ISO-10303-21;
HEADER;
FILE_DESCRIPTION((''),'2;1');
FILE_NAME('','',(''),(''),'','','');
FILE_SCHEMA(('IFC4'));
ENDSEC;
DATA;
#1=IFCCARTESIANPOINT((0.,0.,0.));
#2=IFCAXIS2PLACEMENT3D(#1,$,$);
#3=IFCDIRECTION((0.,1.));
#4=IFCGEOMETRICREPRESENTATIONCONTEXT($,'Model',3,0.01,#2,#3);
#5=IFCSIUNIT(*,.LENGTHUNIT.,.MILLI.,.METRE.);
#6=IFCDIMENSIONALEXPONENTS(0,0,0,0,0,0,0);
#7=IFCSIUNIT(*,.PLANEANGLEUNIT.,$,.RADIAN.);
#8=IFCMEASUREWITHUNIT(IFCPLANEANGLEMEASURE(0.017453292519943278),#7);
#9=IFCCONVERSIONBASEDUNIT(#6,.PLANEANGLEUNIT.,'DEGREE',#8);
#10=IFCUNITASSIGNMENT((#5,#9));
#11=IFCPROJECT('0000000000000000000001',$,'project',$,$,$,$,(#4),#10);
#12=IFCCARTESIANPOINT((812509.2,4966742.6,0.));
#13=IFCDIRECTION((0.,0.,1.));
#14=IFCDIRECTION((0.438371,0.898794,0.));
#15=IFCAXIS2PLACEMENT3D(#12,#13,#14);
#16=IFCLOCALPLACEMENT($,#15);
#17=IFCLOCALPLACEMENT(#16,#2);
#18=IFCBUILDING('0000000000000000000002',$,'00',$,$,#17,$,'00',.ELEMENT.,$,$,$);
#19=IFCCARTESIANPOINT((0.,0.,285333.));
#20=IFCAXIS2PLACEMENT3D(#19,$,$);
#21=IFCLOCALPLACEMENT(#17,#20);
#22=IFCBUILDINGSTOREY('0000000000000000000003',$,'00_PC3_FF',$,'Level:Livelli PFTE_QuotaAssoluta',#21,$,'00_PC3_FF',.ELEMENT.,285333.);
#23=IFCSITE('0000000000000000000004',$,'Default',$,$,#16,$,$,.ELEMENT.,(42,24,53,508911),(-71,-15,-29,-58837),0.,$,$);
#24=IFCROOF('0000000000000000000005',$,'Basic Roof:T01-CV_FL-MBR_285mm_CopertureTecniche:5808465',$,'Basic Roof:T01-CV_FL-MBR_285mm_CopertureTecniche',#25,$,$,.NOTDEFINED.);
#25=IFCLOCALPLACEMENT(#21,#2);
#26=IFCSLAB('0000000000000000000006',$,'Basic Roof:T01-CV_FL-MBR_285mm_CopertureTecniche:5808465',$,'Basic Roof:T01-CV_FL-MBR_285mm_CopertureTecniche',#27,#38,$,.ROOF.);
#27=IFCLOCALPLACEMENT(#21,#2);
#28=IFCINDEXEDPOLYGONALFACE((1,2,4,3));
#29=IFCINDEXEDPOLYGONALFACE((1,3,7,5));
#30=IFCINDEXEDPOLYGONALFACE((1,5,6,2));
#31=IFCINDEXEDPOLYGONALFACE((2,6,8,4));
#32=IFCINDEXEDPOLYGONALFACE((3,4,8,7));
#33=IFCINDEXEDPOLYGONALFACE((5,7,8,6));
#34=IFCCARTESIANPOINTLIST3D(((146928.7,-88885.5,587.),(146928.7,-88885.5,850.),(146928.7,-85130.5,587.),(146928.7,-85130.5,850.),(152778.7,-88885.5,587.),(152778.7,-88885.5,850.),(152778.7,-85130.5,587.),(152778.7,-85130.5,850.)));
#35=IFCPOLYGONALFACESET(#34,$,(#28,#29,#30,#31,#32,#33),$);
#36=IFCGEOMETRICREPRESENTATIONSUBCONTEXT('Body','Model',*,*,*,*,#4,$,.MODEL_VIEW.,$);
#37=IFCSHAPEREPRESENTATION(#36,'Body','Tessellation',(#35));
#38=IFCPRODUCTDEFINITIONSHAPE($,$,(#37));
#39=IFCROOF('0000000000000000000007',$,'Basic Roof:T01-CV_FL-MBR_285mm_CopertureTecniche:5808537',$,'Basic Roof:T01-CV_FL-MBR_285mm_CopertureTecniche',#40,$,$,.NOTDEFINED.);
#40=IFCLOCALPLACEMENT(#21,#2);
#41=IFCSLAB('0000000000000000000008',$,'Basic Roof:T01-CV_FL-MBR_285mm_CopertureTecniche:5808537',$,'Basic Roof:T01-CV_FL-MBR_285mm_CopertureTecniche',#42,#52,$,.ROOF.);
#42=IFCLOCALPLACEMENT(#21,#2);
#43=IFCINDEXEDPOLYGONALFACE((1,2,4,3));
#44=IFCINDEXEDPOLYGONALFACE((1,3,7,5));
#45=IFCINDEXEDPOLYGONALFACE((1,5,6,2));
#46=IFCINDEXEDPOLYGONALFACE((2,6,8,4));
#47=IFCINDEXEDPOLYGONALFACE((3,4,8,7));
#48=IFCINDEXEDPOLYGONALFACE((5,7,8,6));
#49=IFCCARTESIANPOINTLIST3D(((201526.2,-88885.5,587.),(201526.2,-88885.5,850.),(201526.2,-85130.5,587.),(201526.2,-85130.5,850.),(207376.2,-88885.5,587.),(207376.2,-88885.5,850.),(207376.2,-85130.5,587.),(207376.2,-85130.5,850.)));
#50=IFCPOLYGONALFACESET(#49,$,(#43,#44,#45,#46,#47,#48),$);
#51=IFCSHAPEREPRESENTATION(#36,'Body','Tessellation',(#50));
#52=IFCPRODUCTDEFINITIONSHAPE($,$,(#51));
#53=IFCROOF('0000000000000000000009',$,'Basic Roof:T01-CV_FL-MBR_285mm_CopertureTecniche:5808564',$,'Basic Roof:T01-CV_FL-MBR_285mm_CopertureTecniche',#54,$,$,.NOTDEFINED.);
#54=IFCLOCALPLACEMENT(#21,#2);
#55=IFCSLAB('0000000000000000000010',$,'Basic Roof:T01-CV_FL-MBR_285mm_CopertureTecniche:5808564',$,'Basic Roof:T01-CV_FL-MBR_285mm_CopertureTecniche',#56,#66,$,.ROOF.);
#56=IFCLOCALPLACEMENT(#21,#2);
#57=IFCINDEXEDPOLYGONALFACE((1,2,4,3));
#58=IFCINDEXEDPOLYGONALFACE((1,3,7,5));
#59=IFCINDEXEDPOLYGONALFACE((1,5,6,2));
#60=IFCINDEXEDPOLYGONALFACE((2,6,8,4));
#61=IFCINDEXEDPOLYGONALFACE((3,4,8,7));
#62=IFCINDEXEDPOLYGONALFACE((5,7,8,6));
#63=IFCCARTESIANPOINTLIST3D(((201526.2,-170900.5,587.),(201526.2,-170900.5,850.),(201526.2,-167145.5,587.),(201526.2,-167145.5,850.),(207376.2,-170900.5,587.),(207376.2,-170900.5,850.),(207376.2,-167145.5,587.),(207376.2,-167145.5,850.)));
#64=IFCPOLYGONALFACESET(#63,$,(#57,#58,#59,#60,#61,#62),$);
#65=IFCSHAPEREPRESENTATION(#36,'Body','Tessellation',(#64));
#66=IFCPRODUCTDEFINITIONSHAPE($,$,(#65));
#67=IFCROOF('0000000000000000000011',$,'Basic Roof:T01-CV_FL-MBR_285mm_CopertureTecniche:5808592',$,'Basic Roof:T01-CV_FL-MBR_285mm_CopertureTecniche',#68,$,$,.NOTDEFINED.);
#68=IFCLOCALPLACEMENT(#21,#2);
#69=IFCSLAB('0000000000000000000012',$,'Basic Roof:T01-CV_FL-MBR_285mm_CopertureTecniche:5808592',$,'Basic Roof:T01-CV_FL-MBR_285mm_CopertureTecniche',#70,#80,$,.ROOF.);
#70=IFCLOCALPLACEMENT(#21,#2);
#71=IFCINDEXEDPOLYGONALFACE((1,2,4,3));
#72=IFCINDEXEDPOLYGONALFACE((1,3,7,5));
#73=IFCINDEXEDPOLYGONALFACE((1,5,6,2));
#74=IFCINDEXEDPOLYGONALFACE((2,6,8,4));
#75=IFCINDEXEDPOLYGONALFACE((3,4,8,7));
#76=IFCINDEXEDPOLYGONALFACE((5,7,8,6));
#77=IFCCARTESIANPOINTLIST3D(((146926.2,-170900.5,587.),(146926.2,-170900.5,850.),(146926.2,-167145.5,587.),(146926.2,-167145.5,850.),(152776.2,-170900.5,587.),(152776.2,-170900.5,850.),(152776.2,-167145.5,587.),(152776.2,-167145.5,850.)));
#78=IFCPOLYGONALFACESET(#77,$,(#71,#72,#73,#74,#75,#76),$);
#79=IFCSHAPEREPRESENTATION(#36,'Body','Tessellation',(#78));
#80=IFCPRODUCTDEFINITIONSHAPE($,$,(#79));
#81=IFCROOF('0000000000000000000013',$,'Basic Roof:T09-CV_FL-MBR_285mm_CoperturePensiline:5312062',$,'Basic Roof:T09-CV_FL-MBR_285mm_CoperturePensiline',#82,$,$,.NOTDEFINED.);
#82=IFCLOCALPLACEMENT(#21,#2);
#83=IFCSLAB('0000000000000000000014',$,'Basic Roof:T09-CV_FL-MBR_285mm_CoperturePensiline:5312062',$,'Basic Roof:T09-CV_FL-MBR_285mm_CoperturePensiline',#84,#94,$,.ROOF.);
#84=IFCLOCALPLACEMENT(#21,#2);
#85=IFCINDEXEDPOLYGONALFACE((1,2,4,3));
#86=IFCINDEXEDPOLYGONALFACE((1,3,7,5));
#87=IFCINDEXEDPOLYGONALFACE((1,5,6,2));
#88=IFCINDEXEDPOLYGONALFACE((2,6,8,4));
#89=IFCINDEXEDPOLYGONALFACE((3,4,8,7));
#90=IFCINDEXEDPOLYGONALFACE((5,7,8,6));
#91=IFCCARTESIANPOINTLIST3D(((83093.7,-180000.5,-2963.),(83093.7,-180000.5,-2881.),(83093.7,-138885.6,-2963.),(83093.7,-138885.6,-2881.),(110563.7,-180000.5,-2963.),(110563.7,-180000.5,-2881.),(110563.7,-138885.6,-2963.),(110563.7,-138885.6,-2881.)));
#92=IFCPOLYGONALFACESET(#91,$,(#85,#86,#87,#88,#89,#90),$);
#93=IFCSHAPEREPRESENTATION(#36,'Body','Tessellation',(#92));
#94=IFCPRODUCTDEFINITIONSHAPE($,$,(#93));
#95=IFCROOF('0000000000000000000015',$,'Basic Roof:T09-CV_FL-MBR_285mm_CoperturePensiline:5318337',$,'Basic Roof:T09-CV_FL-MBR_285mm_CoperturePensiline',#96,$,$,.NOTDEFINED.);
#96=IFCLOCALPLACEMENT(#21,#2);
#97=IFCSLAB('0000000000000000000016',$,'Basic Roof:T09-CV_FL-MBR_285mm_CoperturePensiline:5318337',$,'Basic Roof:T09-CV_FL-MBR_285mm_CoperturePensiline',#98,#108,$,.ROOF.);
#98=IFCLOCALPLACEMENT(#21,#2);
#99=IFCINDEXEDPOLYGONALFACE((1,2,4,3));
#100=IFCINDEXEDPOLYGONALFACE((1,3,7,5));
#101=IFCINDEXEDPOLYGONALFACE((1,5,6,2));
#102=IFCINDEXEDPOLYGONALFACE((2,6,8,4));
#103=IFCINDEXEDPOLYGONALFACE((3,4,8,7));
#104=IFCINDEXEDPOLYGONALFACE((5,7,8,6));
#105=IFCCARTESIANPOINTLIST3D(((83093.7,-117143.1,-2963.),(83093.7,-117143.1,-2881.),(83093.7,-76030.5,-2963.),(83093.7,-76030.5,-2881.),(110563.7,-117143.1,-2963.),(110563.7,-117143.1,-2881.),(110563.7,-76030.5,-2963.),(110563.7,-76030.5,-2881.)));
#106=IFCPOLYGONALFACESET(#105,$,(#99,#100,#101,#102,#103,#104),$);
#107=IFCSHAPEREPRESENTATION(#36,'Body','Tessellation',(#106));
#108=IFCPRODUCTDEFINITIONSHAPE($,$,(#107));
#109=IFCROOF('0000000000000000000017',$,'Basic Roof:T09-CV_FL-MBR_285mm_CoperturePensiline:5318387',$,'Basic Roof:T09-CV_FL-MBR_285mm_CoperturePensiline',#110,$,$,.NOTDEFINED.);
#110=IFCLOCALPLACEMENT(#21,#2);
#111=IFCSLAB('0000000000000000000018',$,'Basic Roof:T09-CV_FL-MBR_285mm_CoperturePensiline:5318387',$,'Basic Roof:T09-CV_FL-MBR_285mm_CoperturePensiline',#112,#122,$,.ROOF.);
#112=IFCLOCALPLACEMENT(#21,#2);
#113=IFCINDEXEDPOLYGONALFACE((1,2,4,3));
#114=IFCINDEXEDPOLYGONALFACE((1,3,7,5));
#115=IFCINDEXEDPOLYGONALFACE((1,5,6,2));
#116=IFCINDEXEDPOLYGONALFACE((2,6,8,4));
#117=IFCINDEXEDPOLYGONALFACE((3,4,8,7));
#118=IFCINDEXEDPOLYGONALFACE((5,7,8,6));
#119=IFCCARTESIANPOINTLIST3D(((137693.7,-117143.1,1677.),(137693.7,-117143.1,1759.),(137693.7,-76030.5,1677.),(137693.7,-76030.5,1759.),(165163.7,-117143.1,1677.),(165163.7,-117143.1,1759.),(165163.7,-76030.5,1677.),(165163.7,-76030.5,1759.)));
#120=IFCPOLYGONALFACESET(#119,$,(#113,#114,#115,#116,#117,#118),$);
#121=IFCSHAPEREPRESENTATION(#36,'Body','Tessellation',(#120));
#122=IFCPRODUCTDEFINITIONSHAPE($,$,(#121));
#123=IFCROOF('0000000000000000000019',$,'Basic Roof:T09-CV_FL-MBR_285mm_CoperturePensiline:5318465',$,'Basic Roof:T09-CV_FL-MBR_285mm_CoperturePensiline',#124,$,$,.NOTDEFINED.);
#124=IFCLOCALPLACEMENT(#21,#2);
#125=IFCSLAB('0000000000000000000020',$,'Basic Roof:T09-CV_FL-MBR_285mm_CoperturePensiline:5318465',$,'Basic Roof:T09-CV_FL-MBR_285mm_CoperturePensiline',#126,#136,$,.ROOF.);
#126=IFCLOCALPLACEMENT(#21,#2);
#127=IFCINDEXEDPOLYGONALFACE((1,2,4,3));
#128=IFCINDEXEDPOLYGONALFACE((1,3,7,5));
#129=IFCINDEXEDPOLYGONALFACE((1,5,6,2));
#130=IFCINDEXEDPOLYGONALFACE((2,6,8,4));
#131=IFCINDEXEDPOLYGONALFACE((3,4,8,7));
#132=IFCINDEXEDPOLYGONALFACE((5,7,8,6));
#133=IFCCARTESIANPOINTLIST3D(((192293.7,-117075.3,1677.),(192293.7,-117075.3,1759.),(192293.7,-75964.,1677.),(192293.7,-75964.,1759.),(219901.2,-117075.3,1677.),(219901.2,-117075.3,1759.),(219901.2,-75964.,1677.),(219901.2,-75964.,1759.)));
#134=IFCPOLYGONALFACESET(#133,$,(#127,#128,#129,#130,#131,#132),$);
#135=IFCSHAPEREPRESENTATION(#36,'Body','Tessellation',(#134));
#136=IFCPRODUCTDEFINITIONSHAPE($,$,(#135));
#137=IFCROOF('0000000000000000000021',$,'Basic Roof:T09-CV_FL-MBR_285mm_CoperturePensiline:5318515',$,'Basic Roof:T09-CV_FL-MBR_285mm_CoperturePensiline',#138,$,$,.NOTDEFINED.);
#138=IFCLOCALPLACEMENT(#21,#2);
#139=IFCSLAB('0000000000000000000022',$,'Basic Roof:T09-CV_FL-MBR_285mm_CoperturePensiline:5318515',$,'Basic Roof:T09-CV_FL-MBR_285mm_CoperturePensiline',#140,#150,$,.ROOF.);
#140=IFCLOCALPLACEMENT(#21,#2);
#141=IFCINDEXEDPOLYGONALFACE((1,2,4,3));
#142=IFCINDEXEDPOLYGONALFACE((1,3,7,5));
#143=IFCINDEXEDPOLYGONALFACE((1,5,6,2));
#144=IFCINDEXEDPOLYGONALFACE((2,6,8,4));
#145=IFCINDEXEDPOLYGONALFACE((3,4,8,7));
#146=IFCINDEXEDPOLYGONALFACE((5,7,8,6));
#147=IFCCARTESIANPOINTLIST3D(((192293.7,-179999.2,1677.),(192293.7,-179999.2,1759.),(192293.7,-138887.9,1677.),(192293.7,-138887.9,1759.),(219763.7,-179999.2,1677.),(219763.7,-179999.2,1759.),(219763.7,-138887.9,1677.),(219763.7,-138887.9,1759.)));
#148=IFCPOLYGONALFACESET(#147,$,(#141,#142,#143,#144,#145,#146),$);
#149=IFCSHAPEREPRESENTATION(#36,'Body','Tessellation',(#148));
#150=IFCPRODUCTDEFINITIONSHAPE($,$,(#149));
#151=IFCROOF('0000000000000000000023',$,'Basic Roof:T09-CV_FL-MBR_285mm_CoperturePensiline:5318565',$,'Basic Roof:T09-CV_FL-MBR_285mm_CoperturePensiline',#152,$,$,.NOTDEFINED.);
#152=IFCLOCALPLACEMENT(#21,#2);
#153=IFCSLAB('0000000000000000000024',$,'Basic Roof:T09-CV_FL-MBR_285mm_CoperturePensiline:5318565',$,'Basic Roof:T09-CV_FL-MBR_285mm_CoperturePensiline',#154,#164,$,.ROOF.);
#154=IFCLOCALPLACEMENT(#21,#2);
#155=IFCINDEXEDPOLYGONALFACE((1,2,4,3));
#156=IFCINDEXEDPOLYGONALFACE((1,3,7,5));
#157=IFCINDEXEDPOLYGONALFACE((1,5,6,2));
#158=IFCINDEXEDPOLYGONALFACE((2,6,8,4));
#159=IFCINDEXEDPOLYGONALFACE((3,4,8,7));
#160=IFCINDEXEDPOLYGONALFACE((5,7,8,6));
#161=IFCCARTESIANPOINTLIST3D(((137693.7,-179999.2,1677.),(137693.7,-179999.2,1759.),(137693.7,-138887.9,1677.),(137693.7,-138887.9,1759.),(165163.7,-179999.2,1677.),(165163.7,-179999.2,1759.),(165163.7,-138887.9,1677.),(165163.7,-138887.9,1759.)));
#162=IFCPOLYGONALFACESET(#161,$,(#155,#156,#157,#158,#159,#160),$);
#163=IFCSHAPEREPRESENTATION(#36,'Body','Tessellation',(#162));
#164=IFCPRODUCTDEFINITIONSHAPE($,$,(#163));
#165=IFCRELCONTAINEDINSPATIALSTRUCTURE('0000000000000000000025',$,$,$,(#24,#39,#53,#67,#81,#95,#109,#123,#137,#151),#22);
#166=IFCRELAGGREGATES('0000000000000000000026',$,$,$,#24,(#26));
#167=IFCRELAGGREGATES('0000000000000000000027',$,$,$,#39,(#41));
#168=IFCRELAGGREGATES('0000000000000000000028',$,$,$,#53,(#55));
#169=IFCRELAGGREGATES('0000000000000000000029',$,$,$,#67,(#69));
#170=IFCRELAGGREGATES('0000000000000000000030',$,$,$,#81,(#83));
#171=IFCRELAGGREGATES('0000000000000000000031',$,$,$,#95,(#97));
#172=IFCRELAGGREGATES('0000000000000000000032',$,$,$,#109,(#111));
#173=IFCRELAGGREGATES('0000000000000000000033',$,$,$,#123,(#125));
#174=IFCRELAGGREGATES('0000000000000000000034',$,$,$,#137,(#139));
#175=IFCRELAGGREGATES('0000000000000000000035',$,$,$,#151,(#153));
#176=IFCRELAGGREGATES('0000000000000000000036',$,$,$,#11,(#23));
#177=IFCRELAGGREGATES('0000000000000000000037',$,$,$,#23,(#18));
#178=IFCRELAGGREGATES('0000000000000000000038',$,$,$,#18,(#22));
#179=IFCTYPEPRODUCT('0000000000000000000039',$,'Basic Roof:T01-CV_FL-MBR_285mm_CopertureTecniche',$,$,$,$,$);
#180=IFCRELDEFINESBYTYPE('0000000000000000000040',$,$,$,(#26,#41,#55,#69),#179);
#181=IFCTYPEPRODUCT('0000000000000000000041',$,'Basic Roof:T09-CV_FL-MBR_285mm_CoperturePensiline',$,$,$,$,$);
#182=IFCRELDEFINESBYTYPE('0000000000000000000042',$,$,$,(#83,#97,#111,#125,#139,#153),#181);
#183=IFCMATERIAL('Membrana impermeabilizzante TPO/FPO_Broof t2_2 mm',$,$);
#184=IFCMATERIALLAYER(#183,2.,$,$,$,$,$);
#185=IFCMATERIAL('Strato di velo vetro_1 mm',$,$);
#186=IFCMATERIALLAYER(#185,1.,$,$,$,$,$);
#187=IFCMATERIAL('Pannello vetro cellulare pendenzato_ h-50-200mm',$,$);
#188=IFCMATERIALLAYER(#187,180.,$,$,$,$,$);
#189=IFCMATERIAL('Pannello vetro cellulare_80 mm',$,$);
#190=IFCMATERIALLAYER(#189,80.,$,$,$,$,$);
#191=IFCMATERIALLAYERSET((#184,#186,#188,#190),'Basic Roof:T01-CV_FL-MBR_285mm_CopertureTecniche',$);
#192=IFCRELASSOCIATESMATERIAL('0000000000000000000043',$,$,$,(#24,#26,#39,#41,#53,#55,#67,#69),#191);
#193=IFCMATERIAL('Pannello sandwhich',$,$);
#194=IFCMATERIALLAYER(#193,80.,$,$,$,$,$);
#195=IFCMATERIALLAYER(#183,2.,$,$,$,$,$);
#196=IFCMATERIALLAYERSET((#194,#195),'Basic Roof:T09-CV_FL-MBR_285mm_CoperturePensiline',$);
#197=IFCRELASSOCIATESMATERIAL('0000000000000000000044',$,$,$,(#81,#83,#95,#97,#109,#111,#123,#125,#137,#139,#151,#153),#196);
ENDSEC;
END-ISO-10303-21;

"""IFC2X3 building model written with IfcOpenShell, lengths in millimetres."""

from ifc_helpers import new_model, entity, si_unit, converted_unit, direction, frame, frame_2d, origin, origin_2d_with_axis, place, context, subcontext, project, spatial, rectangle, extrude, material, layer, layer_set, type_object, element, aggregate, save


model = new_model("IFC2X3")

# Units and contexts
model_context = context("Model", 3, precision=0.01, world=origin(), true_north=direction((0.0, 1.0)))
body_context = subcontext(model_context, "Body", "Model", "MODEL_VIEW")
ifc_project = project(units=[si_unit("LENGTHUNIT", "METRE", prefix="MILLI"), converted_unit("PLANEANGLEUNIT", "DEGREE", entity("IfcPlaneAngleMeasure", 0.017453292519943278), si_unit("PLANEANGLEUNIT", "RADIAN"), dimensions=[0, 0, 0, 0, 0, 0, 0])], contexts=[model_context])

# Site, building, storey
site_placement = place(None, frame((812509.2, 4966742.6, 0.0), z_axis=(0.0, 0.0, 1.0), x_axis=(0.438371, 0.898794, 0.0)))
site = spatial("IfcSite", under=ifc_project, at=site_placement, Name="Default", CompositionType="ELEMENT", RefLatitude=(42, 24, 53, 508911), RefLongitude=(-71, -15, -29, -58837), RefElevation=0.0)
building_placement = place(site_placement, origin())
building = spatial("IfcBuilding", under=site, at=building_placement, Name="00", LongName="00", CompositionType="ELEMENT")
storey_placement = place(building_placement, frame((0.0, 0.0, 285333.0)))
storey = spatial("IfcBuildingStorey", under=building, at=storey_placement, Name="00_PC3_FF", ObjectType="Level:Livelli PFTE_QuotaAssoluta", LongName="00_PC3_FF", CompositionType="ELEMENT", Elevation=285333.0)

# Roofs, slabs
ifc_material_1 = material(Name="Membrana impermeabilizzante TPO/FPO_Broof t2_2 mm")
ifc_layer_1 = layer(ifc_material_1, 2.0)
ifc_material_2 = material(Name="Strato di velo vetro_1 mm")
ifc_layer_2 = layer(ifc_material_2, 1.0)
ifc_material_3 = material(Name="Pannello vetro cellulare pendenzato_ h-50-200mm")
ifc_layer_3 = layer(ifc_material_3, 180.0)
ifc_material_4 = material(Name="Pannello vetro cellulare_80 mm")
ifc_layer_4 = layer(ifc_material_4, 80.0)
ifc_layer_set_1 = layer_set([ifc_layer_1, ifc_layer_2, ifc_layer_3, ifc_layer_4], Name="Basic Roof:T01-CV_FL-MBR_285mm_CopertureTecniche")
roof_1_placement = place(storey_placement, frame((146928.7, -88885.5, 587.0)))
roof_1 = element("IfcRoof", 1, at=roof_1_placement, inside=storey, material=ifc_layer_set_1, Name="Basic Roof:T01-CV_FL-MBR_285mm_CopertureTecniche:5808465", ObjectType="Basic Roof:T01-CV_FL-MBR_285mm_CopertureTecniche", ShapeType="NOTDEFINED")
type_product_1 = type_object("IfcTypeProduct", Name="Basic Roof:T01-CV_FL-MBR_285mm_CopertureTecniche")
slab_1_placement = place(roof_1_placement, origin())
slab_1 = element("IfcSlab", 2, at=slab_1_placement, type_object=type_product_1, material=ifc_layer_set_1, Name="Basic Roof:T01-CV_FL-MBR_285mm_CopertureTecniche:5808465", ObjectType="Basic Roof:T01-CV_FL-MBR_285mm_CopertureTecniche", PredefinedType="ROOF", context=body_context, shape_type="SweptSolid", body=[
    extrude(rectangle(XDim=5850.0, YDim=3755.0, at=origin_2d_with_axis()), frame((2925.0, 1877.5, 0.0)), (0.0, 0.0, 1.0), 263.0),
])
aggregate(roof_1, [slab_1])
roof_2_placement = place(storey_placement, frame((201526.2, -88885.5, 587.0)))
roof_2 = element("IfcRoof", 3, at=roof_2_placement, inside=storey, material=ifc_layer_set_1, Name="Basic Roof:T01-CV_FL-MBR_285mm_CopertureTecniche:5808537", ObjectType="Basic Roof:T01-CV_FL-MBR_285mm_CopertureTecniche", ShapeType="NOTDEFINED")
slab_2_placement = place(roof_2_placement, origin())
slab_2 = element("IfcSlab", 4, at=slab_2_placement, type_object=type_product_1, material=ifc_layer_set_1, Name="Basic Roof:T01-CV_FL-MBR_285mm_CopertureTecniche:5808537", ObjectType="Basic Roof:T01-CV_FL-MBR_285mm_CopertureTecniche", PredefinedType="ROOF", context=body_context, shape_type="SweptSolid", body=[
    extrude(rectangle(XDim=5850.0, YDim=3755.0, at=origin_2d_with_axis()), frame((2925.0, 1877.5, 0.0)), (0.0, 0.0, 1.0), 263.0),
])
aggregate(roof_2, [slab_2])
roof_3_placement = place(storey_placement, frame((201526.2, -170900.5, 587.0)))
roof_3 = element("IfcRoof", 5, at=roof_3_placement, inside=storey, material=ifc_layer_set_1, Name="Basic Roof:T01-CV_FL-MBR_285mm_CopertureTecniche:5808564", ObjectType="Basic Roof:T01-CV_FL-MBR_285mm_CopertureTecniche", ShapeType="NOTDEFINED")
slab_3_placement = place(roof_3_placement, origin())
slab_3 = element("IfcSlab", 6, at=slab_3_placement, type_object=type_product_1, material=ifc_layer_set_1, Name="Basic Roof:T01-CV_FL-MBR_285mm_CopertureTecniche:5808564", ObjectType="Basic Roof:T01-CV_FL-MBR_285mm_CopertureTecniche", PredefinedType="ROOF", context=body_context, shape_type="SweptSolid", body=[
    extrude(rectangle(XDim=5850.0, YDim=3755.0, at=origin_2d_with_axis()), frame((2925.0, 1877.5, 0.0)), (0.0, 0.0, 1.0), 263.0),
])
aggregate(roof_3, [slab_3])
roof_4_placement = place(storey_placement, frame((146926.2, -170900.5, 587.0)))
roof_4 = element("IfcRoof", 7, at=roof_4_placement, inside=storey, material=ifc_layer_set_1, Name="Basic Roof:T01-CV_FL-MBR_285mm_CopertureTecniche:5808592", ObjectType="Basic Roof:T01-CV_FL-MBR_285mm_CopertureTecniche", ShapeType="NOTDEFINED")
slab_4_placement = place(roof_4_placement, origin())
slab_4 = element("IfcSlab", 8, at=slab_4_placement, type_object=type_product_1, material=ifc_layer_set_1, Name="Basic Roof:T01-CV_FL-MBR_285mm_CopertureTecniche:5808592", ObjectType="Basic Roof:T01-CV_FL-MBR_285mm_CopertureTecniche", PredefinedType="ROOF", context=body_context, shape_type="SweptSolid", body=[
    extrude(rectangle(XDim=5850.0, YDim=3755.0, at=origin_2d_with_axis()), frame((2925.0, 1877.5, 0.0)), (0.0, 0.0, 1.0), 263.0),
])
aggregate(roof_4, [slab_4])
ifc_material_5 = material(Name="Pannello sandwhich")
ifc_layer_5 = layer(ifc_material_5, 80.0)
ifc_layer_6 = layer(ifc_material_1, 2.0)
ifc_layer_set_2 = layer_set([ifc_layer_5, ifc_layer_6], Name="Basic Roof:T09-CV_FL-MBR_285mm_CoperturePensiline")
roof_5_placement = place(storey_placement, frame((83093.7, -180000.5, -2963.0)))
roof_5 = element("IfcRoof", 9, at=roof_5_placement, inside=storey, material=ifc_layer_set_2, Name="Basic Roof:T09-CV_FL-MBR_285mm_CoperturePensiline:5312062", ObjectType="Basic Roof:T09-CV_FL-MBR_285mm_CoperturePensiline", ShapeType="NOTDEFINED")
type_product_2 = type_object("IfcTypeProduct", Name="Basic Roof:T09-CV_FL-MBR_285mm_CoperturePensiline")
slab_5_placement = place(roof_5_placement, origin())
slab_5 = element("IfcSlab", 10, at=slab_5_placement, type_object=type_product_2, material=ifc_layer_set_2, Name="Basic Roof:T09-CV_FL-MBR_285mm_CoperturePensiline:5312062", ObjectType="Basic Roof:T09-CV_FL-MBR_285mm_CoperturePensiline", PredefinedType="ROOF", context=body_context, shape_type="SweptSolid", body=[
    extrude(rectangle(XDim=41114.9, YDim=27470.0, at=frame_2d((0.0, 0.0), x_axis=(0.0, 1.0))), frame((13735.0, 20557.4, 0.0)), (0.0, 0.0, 1.0), 82.0),
])
aggregate(roof_5, [slab_5])
roof_6_placement = place(storey_placement, frame((83093.7, -117143.1, -2963.0)))
roof_6 = element("IfcRoof", 11, at=roof_6_placement, inside=storey, material=ifc_layer_set_2, Name="Basic Roof:T09-CV_FL-MBR_285mm_CoperturePensiline:5318337", ObjectType="Basic Roof:T09-CV_FL-MBR_285mm_CoperturePensiline", ShapeType="NOTDEFINED")
slab_6_placement = place(roof_6_placement, origin())
slab_6 = element("IfcSlab", 12, at=slab_6_placement, type_object=type_product_2, material=ifc_layer_set_2, Name="Basic Roof:T09-CV_FL-MBR_285mm_CoperturePensiline:5318337", ObjectType="Basic Roof:T09-CV_FL-MBR_285mm_CoperturePensiline", PredefinedType="ROOF", context=body_context, shape_type="SweptSolid", body=[
    extrude(rectangle(XDim=41112.6, YDim=27470.0, at=frame_2d((0.0, 0.0), x_axis=(0.0, 1.0))), frame((13735.0, 20556.3, 0.0)), (0.0, 0.0, 1.0), 82.0),
])
aggregate(roof_6, [slab_6])
roof_7_placement = place(storey_placement, frame((137693.7, -117143.1, 1677.0)))
roof_7 = element("IfcRoof", 13, at=roof_7_placement, inside=storey, material=ifc_layer_set_2, Name="Basic Roof:T09-CV_FL-MBR_285mm_CoperturePensiline:5318387", ObjectType="Basic Roof:T09-CV_FL-MBR_285mm_CoperturePensiline", ShapeType="NOTDEFINED")
slab_7_placement = place(roof_7_placement, origin())
slab_7 = element("IfcSlab", 14, at=slab_7_placement, type_object=type_product_2, material=ifc_layer_set_2, Name="Basic Roof:T09-CV_FL-MBR_285mm_CoperturePensiline:5318387", ObjectType="Basic Roof:T09-CV_FL-MBR_285mm_CoperturePensiline", PredefinedType="ROOF", context=body_context, shape_type="SweptSolid", body=[
    extrude(rectangle(XDim=41112.6, YDim=27470.0, at=frame_2d((0.0, 0.0), x_axis=(0.0, 1.0))), frame((13735.0, 20556.3, 0.0)), (0.0, 0.0, 1.0), 82.0),
])
aggregate(roof_7, [slab_7])
roof_8_placement = place(storey_placement, frame((192293.7, -117075.3, 1677.0)))
roof_8 = element("IfcRoof", 15, at=roof_8_placement, inside=storey, material=ifc_layer_set_2, Name="Basic Roof:T09-CV_FL-MBR_285mm_CoperturePensiline:5318465", ObjectType="Basic Roof:T09-CV_FL-MBR_285mm_CoperturePensiline", ShapeType="NOTDEFINED")
slab_8_placement = place(roof_8_placement, origin())
slab_8 = element("IfcSlab", 16, at=slab_8_placement, type_object=type_product_2, material=ifc_layer_set_2, Name="Basic Roof:T09-CV_FL-MBR_285mm_CoperturePensiline:5318465", ObjectType="Basic Roof:T09-CV_FL-MBR_285mm_CoperturePensiline", PredefinedType="ROOF", context=body_context, shape_type="SweptSolid", body=[
    extrude(rectangle(XDim=41111.3, YDim=27607.5, at=frame_2d((0.0, 0.0), x_axis=(0.0, 1.0))), frame((13803.7, 20555.7, 0.0)), (0.0, 0.0, 1.0), 82.0),
])
aggregate(roof_8, [slab_8])
roof_9_placement = place(storey_placement, frame((192293.7, -179999.2, 1677.0)))
roof_9 = element("IfcRoof", 17, at=roof_9_placement, inside=storey, material=ifc_layer_set_2, Name="Basic Roof:T09-CV_FL-MBR_285mm_CoperturePensiline:5318515", ObjectType="Basic Roof:T09-CV_FL-MBR_285mm_CoperturePensiline", ShapeType="NOTDEFINED")
slab_9_placement = place(roof_9_placement, origin())
slab_9 = element("IfcSlab", 18, at=slab_9_placement, type_object=type_product_2, material=ifc_layer_set_2, Name="Basic Roof:T09-CV_FL-MBR_285mm_CoperturePensiline:5318515", ObjectType="Basic Roof:T09-CV_FL-MBR_285mm_CoperturePensiline", PredefinedType="ROOF", context=body_context, shape_type="SweptSolid", body=[
    extrude(rectangle(XDim=41111.3, YDim=27470.0, at=frame_2d((0.0, 0.0), x_axis=(0.0, 1.0))), frame((13735.0, 20555.7, 0.0)), (0.0, 0.0, 1.0), 82.0),
])
aggregate(roof_9, [slab_9])
roof_10_placement = place(storey_placement, frame((137693.7, -179999.2, 1677.0)))
roof_10 = element("IfcRoof", 19, at=roof_10_placement, inside=storey, material=ifc_layer_set_2, Name="Basic Roof:T09-CV_FL-MBR_285mm_CoperturePensiline:5318565", ObjectType="Basic Roof:T09-CV_FL-MBR_285mm_CoperturePensiline", ShapeType="NOTDEFINED")
slab_10_placement = place(roof_10_placement, origin())
slab_10 = element("IfcSlab", 20, at=slab_10_placement, type_object=type_product_2, material=ifc_layer_set_2, Name="Basic Roof:T09-CV_FL-MBR_285mm_CoperturePensiline:5318565", ObjectType="Basic Roof:T09-CV_FL-MBR_285mm_CoperturePensiline", PredefinedType="ROOF", context=body_context, shape_type="SweptSolid", body=[
    extrude(rectangle(XDim=41111.3, YDim=27470.0, at=frame_2d((0.0, 0.0), x_axis=(0.0, 1.0))), frame((13735.0, 20555.7, 0.0)), (0.0, 0.0, 1.0), 82.0),
])
aggregate(roof_10, [slab_10])

save(model, "model.ifc")
